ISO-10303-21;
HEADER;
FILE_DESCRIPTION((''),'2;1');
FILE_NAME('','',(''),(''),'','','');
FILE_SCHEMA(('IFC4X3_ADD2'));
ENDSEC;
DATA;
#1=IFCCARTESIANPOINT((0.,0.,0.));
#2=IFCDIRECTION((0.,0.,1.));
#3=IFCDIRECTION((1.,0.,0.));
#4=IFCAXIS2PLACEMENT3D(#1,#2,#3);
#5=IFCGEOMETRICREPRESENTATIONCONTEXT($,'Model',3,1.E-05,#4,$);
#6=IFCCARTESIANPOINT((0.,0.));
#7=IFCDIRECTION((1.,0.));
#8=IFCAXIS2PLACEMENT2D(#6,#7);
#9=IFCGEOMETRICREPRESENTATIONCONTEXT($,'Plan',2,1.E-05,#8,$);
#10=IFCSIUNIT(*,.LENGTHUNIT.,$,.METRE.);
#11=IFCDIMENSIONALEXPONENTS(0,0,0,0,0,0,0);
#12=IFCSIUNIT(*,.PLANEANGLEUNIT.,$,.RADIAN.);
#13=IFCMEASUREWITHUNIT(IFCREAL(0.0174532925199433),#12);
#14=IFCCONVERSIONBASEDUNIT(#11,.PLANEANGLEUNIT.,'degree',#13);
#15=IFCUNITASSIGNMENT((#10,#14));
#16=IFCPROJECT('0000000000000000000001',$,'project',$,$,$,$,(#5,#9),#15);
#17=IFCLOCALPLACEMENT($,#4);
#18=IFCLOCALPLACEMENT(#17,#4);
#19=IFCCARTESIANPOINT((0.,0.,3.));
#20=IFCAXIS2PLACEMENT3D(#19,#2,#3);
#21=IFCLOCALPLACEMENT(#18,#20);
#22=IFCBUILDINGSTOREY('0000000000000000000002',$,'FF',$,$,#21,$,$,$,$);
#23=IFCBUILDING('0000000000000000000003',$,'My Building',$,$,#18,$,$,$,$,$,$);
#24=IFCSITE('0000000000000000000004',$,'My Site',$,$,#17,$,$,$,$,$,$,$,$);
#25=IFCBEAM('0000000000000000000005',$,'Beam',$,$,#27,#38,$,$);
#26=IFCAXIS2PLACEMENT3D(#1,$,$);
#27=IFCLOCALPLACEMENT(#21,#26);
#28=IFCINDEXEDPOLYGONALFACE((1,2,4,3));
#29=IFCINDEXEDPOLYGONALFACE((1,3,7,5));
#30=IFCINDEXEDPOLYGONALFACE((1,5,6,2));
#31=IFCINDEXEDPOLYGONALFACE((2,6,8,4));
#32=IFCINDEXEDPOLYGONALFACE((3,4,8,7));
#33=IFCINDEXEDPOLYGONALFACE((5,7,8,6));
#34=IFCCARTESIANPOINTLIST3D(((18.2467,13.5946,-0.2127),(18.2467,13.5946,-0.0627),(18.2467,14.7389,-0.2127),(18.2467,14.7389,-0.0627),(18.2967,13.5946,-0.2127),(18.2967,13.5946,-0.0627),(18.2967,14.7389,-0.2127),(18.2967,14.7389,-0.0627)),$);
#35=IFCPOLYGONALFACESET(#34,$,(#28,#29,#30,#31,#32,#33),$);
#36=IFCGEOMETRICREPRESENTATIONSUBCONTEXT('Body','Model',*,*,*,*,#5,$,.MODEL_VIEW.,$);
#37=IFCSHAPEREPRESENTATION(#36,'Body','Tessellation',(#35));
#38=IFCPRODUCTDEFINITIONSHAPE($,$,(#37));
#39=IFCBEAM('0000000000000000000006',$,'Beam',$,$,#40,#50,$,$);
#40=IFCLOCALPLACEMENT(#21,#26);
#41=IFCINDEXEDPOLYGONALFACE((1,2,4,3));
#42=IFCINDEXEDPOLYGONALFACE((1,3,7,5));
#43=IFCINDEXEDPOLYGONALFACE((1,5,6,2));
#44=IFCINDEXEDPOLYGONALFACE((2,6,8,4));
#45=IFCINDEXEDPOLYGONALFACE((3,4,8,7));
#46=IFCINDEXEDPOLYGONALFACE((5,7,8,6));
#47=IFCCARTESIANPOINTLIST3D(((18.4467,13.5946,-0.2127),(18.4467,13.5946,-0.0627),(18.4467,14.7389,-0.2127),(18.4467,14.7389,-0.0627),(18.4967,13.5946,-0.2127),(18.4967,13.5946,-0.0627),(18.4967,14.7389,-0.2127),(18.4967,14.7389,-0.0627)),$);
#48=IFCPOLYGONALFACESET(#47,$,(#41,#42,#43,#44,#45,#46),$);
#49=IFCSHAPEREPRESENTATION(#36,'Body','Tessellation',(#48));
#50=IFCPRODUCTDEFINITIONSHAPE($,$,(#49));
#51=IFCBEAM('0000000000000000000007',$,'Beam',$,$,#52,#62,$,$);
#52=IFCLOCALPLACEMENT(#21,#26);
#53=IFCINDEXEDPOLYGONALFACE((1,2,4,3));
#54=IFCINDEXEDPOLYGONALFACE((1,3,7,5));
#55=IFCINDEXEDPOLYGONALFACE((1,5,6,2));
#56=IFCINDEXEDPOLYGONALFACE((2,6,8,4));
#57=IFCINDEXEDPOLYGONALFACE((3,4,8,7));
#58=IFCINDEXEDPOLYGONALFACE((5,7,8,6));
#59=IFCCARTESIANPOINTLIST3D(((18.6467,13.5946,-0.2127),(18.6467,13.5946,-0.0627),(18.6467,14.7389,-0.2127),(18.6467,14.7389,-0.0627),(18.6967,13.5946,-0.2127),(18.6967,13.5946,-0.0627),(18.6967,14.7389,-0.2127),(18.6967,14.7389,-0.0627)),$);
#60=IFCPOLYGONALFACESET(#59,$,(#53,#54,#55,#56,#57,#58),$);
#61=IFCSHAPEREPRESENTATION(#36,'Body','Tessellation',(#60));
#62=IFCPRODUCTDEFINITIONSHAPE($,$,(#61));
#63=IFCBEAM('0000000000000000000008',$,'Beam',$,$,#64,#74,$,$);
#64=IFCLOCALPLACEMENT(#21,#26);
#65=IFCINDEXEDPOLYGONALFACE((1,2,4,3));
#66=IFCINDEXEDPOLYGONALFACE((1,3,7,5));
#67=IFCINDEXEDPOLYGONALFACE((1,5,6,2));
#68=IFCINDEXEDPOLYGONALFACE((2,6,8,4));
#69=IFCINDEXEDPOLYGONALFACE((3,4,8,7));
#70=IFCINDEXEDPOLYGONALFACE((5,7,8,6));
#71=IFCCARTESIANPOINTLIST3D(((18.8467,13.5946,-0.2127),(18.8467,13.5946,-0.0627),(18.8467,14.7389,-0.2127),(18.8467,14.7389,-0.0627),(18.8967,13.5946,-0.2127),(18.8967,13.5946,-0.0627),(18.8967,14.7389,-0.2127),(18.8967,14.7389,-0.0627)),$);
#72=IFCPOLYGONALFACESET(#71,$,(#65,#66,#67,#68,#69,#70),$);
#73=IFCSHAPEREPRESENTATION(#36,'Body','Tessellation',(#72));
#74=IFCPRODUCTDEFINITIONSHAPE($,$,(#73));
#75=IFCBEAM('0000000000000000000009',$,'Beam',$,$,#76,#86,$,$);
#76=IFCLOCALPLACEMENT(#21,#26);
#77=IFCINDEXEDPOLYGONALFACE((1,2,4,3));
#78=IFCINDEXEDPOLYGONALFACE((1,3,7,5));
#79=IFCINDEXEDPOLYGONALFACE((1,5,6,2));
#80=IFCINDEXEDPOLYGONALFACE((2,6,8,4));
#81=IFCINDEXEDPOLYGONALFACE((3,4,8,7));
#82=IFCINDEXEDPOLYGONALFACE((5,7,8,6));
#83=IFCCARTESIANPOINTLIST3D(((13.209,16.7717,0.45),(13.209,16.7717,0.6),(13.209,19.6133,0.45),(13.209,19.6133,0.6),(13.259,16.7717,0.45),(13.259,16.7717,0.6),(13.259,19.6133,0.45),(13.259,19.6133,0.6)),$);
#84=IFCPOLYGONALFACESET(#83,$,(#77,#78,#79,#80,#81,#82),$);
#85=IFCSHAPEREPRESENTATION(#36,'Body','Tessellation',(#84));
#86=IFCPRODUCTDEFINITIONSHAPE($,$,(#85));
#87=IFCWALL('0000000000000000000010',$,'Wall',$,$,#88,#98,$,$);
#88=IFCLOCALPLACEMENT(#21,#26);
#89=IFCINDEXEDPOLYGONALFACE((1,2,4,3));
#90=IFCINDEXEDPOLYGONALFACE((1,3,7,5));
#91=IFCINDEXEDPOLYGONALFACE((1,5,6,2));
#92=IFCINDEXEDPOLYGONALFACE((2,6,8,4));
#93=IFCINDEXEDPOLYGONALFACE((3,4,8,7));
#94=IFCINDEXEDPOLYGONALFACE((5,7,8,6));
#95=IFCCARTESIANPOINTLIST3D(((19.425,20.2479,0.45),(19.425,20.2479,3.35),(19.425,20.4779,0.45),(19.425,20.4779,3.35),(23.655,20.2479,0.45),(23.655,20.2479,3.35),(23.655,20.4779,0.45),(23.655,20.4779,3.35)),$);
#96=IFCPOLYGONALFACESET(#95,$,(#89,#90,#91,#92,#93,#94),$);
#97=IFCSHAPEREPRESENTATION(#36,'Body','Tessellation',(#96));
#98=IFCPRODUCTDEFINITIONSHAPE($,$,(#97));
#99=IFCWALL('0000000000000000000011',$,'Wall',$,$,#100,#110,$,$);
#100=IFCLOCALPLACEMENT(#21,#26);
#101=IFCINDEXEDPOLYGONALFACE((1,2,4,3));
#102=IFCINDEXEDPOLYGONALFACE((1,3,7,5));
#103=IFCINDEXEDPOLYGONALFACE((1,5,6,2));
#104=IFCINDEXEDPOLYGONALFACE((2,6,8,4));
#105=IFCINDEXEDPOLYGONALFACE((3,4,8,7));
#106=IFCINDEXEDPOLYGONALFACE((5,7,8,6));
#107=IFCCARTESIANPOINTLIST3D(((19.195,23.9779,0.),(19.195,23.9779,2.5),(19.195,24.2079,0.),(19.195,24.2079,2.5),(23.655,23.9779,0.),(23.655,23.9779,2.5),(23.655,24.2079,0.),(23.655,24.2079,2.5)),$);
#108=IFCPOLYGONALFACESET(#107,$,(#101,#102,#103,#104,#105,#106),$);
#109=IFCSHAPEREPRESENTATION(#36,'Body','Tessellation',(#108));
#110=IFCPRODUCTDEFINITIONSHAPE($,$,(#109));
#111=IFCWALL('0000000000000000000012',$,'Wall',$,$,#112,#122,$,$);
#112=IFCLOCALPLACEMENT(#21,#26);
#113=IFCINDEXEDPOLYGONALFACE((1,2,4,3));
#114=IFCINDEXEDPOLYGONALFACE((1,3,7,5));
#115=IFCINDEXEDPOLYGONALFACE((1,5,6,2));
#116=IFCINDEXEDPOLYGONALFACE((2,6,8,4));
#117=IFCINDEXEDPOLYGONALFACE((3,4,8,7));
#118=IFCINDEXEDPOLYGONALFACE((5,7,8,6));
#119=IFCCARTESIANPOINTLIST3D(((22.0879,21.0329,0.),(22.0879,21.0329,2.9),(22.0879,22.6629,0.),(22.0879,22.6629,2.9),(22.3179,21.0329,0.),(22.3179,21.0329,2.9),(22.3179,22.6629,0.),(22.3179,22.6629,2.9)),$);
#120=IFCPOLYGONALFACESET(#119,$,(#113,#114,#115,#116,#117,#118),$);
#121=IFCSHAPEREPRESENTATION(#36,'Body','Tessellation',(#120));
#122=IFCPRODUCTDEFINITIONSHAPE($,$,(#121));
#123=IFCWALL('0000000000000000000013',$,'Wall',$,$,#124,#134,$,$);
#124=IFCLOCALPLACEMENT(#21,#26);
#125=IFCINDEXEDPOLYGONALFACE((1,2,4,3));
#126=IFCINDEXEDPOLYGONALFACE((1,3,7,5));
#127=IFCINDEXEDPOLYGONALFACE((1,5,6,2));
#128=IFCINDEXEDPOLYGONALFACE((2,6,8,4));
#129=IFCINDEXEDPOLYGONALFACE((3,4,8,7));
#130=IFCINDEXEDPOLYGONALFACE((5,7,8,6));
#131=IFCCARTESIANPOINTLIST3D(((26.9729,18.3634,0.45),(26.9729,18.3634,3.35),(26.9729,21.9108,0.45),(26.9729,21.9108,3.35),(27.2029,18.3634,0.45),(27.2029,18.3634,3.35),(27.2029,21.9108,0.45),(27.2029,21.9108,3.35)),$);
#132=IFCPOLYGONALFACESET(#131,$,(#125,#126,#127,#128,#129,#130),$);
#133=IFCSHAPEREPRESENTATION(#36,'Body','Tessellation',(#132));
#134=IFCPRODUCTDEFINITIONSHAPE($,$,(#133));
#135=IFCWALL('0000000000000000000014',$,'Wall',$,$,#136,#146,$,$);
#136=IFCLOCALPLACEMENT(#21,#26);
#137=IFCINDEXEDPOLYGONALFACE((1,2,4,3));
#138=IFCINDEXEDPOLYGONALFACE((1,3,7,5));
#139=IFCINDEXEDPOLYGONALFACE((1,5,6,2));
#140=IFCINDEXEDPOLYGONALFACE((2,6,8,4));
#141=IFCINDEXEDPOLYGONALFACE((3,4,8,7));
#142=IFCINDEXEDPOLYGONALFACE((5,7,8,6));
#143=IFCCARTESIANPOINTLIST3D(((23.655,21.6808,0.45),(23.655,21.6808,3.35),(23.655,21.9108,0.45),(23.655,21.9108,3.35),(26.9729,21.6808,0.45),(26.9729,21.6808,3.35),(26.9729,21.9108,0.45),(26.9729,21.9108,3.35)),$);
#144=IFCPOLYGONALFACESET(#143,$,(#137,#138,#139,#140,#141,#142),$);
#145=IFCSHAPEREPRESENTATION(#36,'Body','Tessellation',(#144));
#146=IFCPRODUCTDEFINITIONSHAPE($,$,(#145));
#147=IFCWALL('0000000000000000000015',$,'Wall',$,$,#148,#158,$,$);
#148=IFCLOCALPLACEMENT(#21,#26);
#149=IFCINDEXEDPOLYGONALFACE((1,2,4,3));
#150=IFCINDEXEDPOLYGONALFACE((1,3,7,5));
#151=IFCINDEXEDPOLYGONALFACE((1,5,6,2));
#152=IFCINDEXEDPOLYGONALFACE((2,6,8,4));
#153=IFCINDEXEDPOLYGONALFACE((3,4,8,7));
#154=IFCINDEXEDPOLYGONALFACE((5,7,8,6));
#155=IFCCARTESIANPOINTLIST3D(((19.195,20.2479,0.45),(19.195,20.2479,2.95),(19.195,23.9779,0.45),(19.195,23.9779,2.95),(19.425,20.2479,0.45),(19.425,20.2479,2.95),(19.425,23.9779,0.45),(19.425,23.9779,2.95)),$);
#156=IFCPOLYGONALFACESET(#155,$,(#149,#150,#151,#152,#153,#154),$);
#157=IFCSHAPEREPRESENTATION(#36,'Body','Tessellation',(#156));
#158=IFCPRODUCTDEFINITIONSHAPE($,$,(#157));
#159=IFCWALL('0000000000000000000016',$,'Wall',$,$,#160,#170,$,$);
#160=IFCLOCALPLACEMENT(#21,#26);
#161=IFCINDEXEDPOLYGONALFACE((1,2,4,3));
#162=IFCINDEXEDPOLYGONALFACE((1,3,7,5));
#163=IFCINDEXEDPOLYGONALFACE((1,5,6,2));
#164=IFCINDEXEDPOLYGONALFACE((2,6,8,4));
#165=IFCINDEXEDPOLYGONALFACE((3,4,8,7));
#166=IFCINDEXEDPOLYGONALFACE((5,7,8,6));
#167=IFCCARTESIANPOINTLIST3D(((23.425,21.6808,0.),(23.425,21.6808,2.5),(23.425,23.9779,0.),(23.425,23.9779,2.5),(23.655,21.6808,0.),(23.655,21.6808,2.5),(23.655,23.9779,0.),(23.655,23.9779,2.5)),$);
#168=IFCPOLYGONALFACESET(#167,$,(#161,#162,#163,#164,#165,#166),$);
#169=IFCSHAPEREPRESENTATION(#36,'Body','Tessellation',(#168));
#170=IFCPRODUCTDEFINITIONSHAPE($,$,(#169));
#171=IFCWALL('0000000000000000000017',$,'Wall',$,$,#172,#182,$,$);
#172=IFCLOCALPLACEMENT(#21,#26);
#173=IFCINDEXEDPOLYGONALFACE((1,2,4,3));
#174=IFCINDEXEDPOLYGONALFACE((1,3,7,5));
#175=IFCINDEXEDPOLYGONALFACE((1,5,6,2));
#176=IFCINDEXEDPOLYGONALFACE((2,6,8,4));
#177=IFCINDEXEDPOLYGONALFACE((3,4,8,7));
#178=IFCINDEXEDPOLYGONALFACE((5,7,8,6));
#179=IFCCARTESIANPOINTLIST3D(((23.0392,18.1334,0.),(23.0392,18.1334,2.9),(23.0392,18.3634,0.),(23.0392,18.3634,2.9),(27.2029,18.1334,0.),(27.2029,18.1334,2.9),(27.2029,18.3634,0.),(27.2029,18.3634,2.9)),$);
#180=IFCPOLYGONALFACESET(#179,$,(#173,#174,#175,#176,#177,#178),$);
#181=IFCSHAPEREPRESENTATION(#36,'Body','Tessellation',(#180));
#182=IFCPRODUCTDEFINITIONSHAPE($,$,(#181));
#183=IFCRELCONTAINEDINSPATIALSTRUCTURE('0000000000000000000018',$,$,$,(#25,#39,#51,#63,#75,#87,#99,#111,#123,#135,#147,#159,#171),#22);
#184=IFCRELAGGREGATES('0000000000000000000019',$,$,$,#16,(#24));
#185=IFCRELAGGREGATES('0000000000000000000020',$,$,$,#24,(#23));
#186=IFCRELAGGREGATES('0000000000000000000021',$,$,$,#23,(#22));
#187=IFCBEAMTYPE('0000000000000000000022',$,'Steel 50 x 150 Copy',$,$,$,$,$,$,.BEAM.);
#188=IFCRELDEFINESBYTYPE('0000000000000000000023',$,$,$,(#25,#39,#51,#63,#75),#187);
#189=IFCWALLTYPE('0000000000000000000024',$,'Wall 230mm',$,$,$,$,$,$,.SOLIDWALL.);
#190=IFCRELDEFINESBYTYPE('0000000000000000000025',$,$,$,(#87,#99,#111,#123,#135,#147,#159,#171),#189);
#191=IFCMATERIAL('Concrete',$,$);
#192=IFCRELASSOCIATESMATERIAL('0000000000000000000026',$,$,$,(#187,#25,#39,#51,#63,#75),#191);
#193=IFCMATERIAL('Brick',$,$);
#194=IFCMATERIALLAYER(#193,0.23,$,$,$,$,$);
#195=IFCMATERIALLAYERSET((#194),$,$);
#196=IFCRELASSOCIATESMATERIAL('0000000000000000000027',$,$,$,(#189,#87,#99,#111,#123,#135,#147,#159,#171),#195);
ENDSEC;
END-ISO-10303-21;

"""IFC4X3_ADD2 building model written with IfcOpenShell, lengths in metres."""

from ifc_helpers import new_model, entity, si_unit, converted_unit, frame, origin_with_axes, origin_2d_with_axis, place, context, subcontext, project, spatial, indexed_curve, rectangle, outline, extrude, material, layer, layer_set, layer_usage, material_profile, profile_set, profile_usage, type_object, element, save


model = new_model("IFC4X3_ADD2")

# Units and contexts
model_context = context("Model", 3, precision=1e-05, world=origin_with_axes())
plan_context = context("Plan", 2, precision=1e-05, world=origin_2d_with_axis())
body_context = subcontext(model_context, "Body", "Model", "MODEL_VIEW")
ifc_project = project(units=[si_unit("LENGTHUNIT", "METRE"), converted_unit("PLANEANGLEUNIT", "degree", entity("IfcReal", 0.0174532925199433), si_unit("PLANEANGLEUNIT", "RADIAN"), dimensions=[0, 0, 0, 0, 0, 0, 0])], contexts=[model_context, plan_context])

# Site, building, storey
site_placement = place(None, origin_with_axes())
site = spatial("IfcSite", under=ifc_project, at=site_placement, Name="My Site")
building_placement = place(site_placement, origin_with_axes())
building = spatial("IfcBuilding", under=site, at=building_placement, Name="My Building")
storey_placement = place(building_placement, frame((0.0, 0.0, 3.0), z_axis=(0.0, 0.0, 1.0), x_axis=(1.0, 0.0, 0.0)))
storey = spatial("IfcBuildingStorey", under=building, at=storey_placement, Name="FF")

# Beams
ifc_material_1 = material(Name="Concrete")
ifc_material_profile = material_profile(ifc_material_1, rectangle(XDim=0.05, YDim=0.15))
ifc_profile_set = profile_set([ifc_material_profile])
beam_type = type_object("IfcBeamType", Name="Steel 50 x 150 Copy", PredefinedType="BEAM", material=ifc_profile_set)
ifc_profile_usage_1 = profile_usage(ifc_profile_set)
beam_1_placement = place(storey_placement, frame((18.2717, 14.7389, -0.1377), z_axis=(0.0, -1.0, 0.0), x_axis=(1.0, 0.0, 0.0)))
element("IfcBeam", 1, at=beam_1_placement, inside=storey, type_object=beam_type, material=ifc_profile_usage_1, Name="Beam", context=body_context, shape_type="SweptSolid", body=[
    extrude(rectangle(XDim=0.05, YDim=0.15), origin_with_axes(), (0.0, 0.0, 1.0), 1.1444),
])
ifc_profile_usage_2 = profile_usage(ifc_profile_set)
beam_2_placement = place(storey_placement, frame((18.4717, 14.7389, -0.1377), z_axis=(0.0, -1.0, 0.0), x_axis=(1.0, 0.0, 0.0)))
element("IfcBeam", 2, at=beam_2_placement, inside=storey, type_object=beam_type, material=ifc_profile_usage_2, Name="Beam", context=body_context, shape_type="SweptSolid", body=[
    extrude(rectangle(XDim=0.05, YDim=0.15), origin_with_axes(), (0.0, 0.0, 1.0), 1.1444),
])
ifc_profile_usage_3 = profile_usage(ifc_profile_set)
beam_3_placement = place(storey_placement, frame((18.6717, 14.7389, -0.1377), z_axis=(0.0, -1.0, 0.0), x_axis=(1.0, 0.0, 0.0)))
element("IfcBeam", 3, at=beam_3_placement, inside=storey, type_object=beam_type, material=ifc_profile_usage_3, Name="Beam", context=body_context, shape_type="SweptSolid", body=[
    extrude(rectangle(XDim=0.05, YDim=0.15), origin_with_axes(), (0.0, 0.0, 1.0), 1.1444),
])
ifc_profile_usage_4 = profile_usage(ifc_profile_set)
beam_4_placement = place(storey_placement, frame((18.8717, 14.7389, -0.1377), z_axis=(0.0, -1.0, 0.0), x_axis=(1.0, 0.0, 0.0)))
element("IfcBeam", 4, at=beam_4_placement, inside=storey, type_object=beam_type, material=ifc_profile_usage_4, Name="Beam", context=body_context, shape_type="SweptSolid", body=[
    extrude(rectangle(XDim=0.05, YDim=0.15), origin_with_axes(), (0.0, 0.0, 1.0), 1.1444),
])
ifc_profile_usage_5 = profile_usage(ifc_profile_set)
beam_5_placement = place(storey_placement, frame((13.234, 16.7717, 0.525), z_axis=(0.0, 1.0, 0.0), x_axis=(-1.0, 0.0, 0.0)))
element("IfcBeam", 5, at=beam_5_placement, inside=storey, type_object=beam_type, material=ifc_profile_usage_5, Name="Beam", context=body_context, shape_type="SweptSolid", body=[
    extrude(rectangle(XDim=0.05, YDim=0.15), origin_with_axes(), (0.0, 0.0, 1.0), 2.8416),
])

# Walls
ifc_material_2 = material(Name="Brick")
ifc_layer = layer(ifc_material_2, 0.23)
ifc_layer_set = layer_set([ifc_layer])
ifc_layer_usage_1 = layer_usage(ifc_layer_set, "AXIS2", "POSITIVE", 0.0)
wall_type = type_object("IfcWallType", Name="Wall 230mm", PredefinedType="SOLIDWALL", material=ifc_layer_set)
wall_1_placement = place(storey_placement, frame((19.425, 20.2479, 0.45), z_axis=(0.0, 0.0, 1.0), x_axis=(1.0, 0.0, 0.0)))
element("IfcWall", 6, at=wall_1_placement, inside=storey, type_object=wall_type, material=ifc_layer_usage_1, Name="Wall", context=body_context, shape_type="SweptSolid", body=[
    extrude(outline(indexed_curve([(0.0, 0.0), (0.0, 0.23), (4.23, 0.23), (4.23, 0.0), (0.0, 0.0)], self_intersect=False)), origin_with_axes(), (0.0, 0.0, 1.0), 2.9),
])
ifc_layer_usage_2 = layer_usage(ifc_layer_set, "AXIS2", "POSITIVE", 0.0)
wall_2_placement = place(storey_placement, frame((19.195, 23.9779, 0.0), z_axis=(0.0, 0.0, 1.0), x_axis=(1.0, 0.0, 0.0)))
element("IfcWall", 7, at=wall_2_placement, inside=storey, type_object=wall_type, material=ifc_layer_usage_2, Name="Wall", context=body_context, shape_type="SweptSolid", body=[
    extrude(outline(indexed_curve([(0.0, 0.0), (0.0, 0.23), (4.46, 0.23), (4.46, 0.0), (0.0, 0.0)], self_intersect=False)), origin_with_axes(), (0.0, 0.0, 1.0), 2.5),
])
ifc_layer_usage_3 = layer_usage(ifc_layer_set, "AXIS2", "POSITIVE", 0.0)
wall_3_placement = place(storey_placement, frame((22.3179, 21.0329, 0.0), z_axis=(0.0, 0.0, 1.0), x_axis=(0.0, 1.0, 0.0)))
element("IfcWall", 8, at=wall_3_placement, inside=storey, type_object=wall_type, material=ifc_layer_usage_3, Name="Wall", context=body_context, shape_type="SweptSolid", body=[
    extrude(outline(indexed_curve([(0.0, 0.0), (0.0, 0.23), (1.63, 0.23), (1.63, 0.0), (0.0, 0.0)], self_intersect=False)), origin_with_axes(), (0.0, 0.0, 1.0), 2.9),
])
ifc_layer_usage_4 = layer_usage(ifc_layer_set, "AXIS2", "POSITIVE", 0.0)
wall_4_placement = place(storey_placement, frame((27.2029, 18.3634, 0.45), z_axis=(0.0, 0.0, 1.0), x_axis=(0.0, 1.0, 0.0)))
element("IfcWall", 9, at=wall_4_placement, inside=storey, type_object=wall_type, material=ifc_layer_usage_4, Name="Wall", context=body_context, shape_type="SweptSolid", body=[
    extrude(outline(indexed_curve([(0.0, 0.0), (0.0, 0.23), (3.5474, 0.23), (3.5474, 0.0), (0.0, 0.0)], self_intersect=False)), origin_with_axes(), (0.0, 0.0, 1.0), 2.9),
])
ifc_layer_usage_5 = layer_usage(ifc_layer_set, "AXIS2", "POSITIVE", 0.0)
wall_5_placement = place(storey_placement, frame((23.655, 21.6808, 0.45), z_axis=(0.0, 0.0, 1.0), x_axis=(1.0, 0.0, 0.0)))
element("IfcWall", 10, at=wall_5_placement, inside=storey, type_object=wall_type, material=ifc_layer_usage_5, Name="Wall", context=body_context, shape_type="SweptSolid", body=[
    extrude(outline(indexed_curve([(0.0, 0.0), (0.0, 0.23), (3.3179, 0.23), (3.3179, 0.0), (0.0, 0.0)], self_intersect=False)), origin_with_axes(), (0.0, 0.0, 1.0), 2.9),
])
ifc_layer_usage_6 = layer_usage(ifc_layer_set, "AXIS2", "POSITIVE", 0.0)
wall_6_placement = place(storey_placement, frame((19.425, 20.2479, 0.45), z_axis=(0.0, 0.0, 1.0), x_axis=(0.0, 1.0, 0.0)))
element("IfcWall", 11, at=wall_6_placement, inside=storey, type_object=wall_type, material=ifc_layer_usage_6, Name="Wall", context=body_context, shape_type="SweptSolid", body=[
    extrude(outline(indexed_curve([(0.0, 0.0), (0.0, 0.23), (3.73, 0.23), (3.73, 0.0), (0.0, 0.0)], self_intersect=False)), origin_with_axes(), (0.0, 0.0, 1.0), 2.5),
])
ifc_layer_usage_7 = layer_usage(ifc_layer_set, "AXIS2", "POSITIVE", 0.0)
wall_7_placement = place(storey_placement, frame((23.655, 21.6808, 0.0), z_axis=(0.0, 0.0, 1.0), x_axis=(0.0, 1.0, 0.0)))
element("IfcWall", 12, at=wall_7_placement, inside=storey, type_object=wall_type, material=ifc_layer_usage_7, Name="Wall", context=body_context, shape_type="SweptSolid", body=[
    extrude(outline(indexed_curve([(0.0, 0.0), (0.0, 0.23), (2.2971, 0.23), (2.2971, 0.0), (0.0, 0.0)], self_intersect=False)), origin_with_axes(), (0.0, 0.0, 1.0), 2.5),
])
ifc_layer_usage_8 = layer_usage(ifc_layer_set, "AXIS2", "POSITIVE", 0.0)
wall_8_placement = place(storey_placement, frame((23.0392, 18.1334, 0.0), z_axis=(0.0, 0.0, 1.0), x_axis=(1.0, 0.0, 0.0)))
element("IfcWall", 13, at=wall_8_placement, inside=storey, type_object=wall_type, material=ifc_layer_usage_8, Name="Wall", context=body_context, shape_type="SweptSolid", body=[
    extrude(outline(indexed_curve([(0.0, 0.0), (0.0, 0.23), (4.1636, 0.23), (4.1636, 0.0), (0.0, 0.0)], self_intersect=False)), origin_with_axes(), (0.0, 0.0, 1.0), 2.9),
])

save(model, "model.ifc")
